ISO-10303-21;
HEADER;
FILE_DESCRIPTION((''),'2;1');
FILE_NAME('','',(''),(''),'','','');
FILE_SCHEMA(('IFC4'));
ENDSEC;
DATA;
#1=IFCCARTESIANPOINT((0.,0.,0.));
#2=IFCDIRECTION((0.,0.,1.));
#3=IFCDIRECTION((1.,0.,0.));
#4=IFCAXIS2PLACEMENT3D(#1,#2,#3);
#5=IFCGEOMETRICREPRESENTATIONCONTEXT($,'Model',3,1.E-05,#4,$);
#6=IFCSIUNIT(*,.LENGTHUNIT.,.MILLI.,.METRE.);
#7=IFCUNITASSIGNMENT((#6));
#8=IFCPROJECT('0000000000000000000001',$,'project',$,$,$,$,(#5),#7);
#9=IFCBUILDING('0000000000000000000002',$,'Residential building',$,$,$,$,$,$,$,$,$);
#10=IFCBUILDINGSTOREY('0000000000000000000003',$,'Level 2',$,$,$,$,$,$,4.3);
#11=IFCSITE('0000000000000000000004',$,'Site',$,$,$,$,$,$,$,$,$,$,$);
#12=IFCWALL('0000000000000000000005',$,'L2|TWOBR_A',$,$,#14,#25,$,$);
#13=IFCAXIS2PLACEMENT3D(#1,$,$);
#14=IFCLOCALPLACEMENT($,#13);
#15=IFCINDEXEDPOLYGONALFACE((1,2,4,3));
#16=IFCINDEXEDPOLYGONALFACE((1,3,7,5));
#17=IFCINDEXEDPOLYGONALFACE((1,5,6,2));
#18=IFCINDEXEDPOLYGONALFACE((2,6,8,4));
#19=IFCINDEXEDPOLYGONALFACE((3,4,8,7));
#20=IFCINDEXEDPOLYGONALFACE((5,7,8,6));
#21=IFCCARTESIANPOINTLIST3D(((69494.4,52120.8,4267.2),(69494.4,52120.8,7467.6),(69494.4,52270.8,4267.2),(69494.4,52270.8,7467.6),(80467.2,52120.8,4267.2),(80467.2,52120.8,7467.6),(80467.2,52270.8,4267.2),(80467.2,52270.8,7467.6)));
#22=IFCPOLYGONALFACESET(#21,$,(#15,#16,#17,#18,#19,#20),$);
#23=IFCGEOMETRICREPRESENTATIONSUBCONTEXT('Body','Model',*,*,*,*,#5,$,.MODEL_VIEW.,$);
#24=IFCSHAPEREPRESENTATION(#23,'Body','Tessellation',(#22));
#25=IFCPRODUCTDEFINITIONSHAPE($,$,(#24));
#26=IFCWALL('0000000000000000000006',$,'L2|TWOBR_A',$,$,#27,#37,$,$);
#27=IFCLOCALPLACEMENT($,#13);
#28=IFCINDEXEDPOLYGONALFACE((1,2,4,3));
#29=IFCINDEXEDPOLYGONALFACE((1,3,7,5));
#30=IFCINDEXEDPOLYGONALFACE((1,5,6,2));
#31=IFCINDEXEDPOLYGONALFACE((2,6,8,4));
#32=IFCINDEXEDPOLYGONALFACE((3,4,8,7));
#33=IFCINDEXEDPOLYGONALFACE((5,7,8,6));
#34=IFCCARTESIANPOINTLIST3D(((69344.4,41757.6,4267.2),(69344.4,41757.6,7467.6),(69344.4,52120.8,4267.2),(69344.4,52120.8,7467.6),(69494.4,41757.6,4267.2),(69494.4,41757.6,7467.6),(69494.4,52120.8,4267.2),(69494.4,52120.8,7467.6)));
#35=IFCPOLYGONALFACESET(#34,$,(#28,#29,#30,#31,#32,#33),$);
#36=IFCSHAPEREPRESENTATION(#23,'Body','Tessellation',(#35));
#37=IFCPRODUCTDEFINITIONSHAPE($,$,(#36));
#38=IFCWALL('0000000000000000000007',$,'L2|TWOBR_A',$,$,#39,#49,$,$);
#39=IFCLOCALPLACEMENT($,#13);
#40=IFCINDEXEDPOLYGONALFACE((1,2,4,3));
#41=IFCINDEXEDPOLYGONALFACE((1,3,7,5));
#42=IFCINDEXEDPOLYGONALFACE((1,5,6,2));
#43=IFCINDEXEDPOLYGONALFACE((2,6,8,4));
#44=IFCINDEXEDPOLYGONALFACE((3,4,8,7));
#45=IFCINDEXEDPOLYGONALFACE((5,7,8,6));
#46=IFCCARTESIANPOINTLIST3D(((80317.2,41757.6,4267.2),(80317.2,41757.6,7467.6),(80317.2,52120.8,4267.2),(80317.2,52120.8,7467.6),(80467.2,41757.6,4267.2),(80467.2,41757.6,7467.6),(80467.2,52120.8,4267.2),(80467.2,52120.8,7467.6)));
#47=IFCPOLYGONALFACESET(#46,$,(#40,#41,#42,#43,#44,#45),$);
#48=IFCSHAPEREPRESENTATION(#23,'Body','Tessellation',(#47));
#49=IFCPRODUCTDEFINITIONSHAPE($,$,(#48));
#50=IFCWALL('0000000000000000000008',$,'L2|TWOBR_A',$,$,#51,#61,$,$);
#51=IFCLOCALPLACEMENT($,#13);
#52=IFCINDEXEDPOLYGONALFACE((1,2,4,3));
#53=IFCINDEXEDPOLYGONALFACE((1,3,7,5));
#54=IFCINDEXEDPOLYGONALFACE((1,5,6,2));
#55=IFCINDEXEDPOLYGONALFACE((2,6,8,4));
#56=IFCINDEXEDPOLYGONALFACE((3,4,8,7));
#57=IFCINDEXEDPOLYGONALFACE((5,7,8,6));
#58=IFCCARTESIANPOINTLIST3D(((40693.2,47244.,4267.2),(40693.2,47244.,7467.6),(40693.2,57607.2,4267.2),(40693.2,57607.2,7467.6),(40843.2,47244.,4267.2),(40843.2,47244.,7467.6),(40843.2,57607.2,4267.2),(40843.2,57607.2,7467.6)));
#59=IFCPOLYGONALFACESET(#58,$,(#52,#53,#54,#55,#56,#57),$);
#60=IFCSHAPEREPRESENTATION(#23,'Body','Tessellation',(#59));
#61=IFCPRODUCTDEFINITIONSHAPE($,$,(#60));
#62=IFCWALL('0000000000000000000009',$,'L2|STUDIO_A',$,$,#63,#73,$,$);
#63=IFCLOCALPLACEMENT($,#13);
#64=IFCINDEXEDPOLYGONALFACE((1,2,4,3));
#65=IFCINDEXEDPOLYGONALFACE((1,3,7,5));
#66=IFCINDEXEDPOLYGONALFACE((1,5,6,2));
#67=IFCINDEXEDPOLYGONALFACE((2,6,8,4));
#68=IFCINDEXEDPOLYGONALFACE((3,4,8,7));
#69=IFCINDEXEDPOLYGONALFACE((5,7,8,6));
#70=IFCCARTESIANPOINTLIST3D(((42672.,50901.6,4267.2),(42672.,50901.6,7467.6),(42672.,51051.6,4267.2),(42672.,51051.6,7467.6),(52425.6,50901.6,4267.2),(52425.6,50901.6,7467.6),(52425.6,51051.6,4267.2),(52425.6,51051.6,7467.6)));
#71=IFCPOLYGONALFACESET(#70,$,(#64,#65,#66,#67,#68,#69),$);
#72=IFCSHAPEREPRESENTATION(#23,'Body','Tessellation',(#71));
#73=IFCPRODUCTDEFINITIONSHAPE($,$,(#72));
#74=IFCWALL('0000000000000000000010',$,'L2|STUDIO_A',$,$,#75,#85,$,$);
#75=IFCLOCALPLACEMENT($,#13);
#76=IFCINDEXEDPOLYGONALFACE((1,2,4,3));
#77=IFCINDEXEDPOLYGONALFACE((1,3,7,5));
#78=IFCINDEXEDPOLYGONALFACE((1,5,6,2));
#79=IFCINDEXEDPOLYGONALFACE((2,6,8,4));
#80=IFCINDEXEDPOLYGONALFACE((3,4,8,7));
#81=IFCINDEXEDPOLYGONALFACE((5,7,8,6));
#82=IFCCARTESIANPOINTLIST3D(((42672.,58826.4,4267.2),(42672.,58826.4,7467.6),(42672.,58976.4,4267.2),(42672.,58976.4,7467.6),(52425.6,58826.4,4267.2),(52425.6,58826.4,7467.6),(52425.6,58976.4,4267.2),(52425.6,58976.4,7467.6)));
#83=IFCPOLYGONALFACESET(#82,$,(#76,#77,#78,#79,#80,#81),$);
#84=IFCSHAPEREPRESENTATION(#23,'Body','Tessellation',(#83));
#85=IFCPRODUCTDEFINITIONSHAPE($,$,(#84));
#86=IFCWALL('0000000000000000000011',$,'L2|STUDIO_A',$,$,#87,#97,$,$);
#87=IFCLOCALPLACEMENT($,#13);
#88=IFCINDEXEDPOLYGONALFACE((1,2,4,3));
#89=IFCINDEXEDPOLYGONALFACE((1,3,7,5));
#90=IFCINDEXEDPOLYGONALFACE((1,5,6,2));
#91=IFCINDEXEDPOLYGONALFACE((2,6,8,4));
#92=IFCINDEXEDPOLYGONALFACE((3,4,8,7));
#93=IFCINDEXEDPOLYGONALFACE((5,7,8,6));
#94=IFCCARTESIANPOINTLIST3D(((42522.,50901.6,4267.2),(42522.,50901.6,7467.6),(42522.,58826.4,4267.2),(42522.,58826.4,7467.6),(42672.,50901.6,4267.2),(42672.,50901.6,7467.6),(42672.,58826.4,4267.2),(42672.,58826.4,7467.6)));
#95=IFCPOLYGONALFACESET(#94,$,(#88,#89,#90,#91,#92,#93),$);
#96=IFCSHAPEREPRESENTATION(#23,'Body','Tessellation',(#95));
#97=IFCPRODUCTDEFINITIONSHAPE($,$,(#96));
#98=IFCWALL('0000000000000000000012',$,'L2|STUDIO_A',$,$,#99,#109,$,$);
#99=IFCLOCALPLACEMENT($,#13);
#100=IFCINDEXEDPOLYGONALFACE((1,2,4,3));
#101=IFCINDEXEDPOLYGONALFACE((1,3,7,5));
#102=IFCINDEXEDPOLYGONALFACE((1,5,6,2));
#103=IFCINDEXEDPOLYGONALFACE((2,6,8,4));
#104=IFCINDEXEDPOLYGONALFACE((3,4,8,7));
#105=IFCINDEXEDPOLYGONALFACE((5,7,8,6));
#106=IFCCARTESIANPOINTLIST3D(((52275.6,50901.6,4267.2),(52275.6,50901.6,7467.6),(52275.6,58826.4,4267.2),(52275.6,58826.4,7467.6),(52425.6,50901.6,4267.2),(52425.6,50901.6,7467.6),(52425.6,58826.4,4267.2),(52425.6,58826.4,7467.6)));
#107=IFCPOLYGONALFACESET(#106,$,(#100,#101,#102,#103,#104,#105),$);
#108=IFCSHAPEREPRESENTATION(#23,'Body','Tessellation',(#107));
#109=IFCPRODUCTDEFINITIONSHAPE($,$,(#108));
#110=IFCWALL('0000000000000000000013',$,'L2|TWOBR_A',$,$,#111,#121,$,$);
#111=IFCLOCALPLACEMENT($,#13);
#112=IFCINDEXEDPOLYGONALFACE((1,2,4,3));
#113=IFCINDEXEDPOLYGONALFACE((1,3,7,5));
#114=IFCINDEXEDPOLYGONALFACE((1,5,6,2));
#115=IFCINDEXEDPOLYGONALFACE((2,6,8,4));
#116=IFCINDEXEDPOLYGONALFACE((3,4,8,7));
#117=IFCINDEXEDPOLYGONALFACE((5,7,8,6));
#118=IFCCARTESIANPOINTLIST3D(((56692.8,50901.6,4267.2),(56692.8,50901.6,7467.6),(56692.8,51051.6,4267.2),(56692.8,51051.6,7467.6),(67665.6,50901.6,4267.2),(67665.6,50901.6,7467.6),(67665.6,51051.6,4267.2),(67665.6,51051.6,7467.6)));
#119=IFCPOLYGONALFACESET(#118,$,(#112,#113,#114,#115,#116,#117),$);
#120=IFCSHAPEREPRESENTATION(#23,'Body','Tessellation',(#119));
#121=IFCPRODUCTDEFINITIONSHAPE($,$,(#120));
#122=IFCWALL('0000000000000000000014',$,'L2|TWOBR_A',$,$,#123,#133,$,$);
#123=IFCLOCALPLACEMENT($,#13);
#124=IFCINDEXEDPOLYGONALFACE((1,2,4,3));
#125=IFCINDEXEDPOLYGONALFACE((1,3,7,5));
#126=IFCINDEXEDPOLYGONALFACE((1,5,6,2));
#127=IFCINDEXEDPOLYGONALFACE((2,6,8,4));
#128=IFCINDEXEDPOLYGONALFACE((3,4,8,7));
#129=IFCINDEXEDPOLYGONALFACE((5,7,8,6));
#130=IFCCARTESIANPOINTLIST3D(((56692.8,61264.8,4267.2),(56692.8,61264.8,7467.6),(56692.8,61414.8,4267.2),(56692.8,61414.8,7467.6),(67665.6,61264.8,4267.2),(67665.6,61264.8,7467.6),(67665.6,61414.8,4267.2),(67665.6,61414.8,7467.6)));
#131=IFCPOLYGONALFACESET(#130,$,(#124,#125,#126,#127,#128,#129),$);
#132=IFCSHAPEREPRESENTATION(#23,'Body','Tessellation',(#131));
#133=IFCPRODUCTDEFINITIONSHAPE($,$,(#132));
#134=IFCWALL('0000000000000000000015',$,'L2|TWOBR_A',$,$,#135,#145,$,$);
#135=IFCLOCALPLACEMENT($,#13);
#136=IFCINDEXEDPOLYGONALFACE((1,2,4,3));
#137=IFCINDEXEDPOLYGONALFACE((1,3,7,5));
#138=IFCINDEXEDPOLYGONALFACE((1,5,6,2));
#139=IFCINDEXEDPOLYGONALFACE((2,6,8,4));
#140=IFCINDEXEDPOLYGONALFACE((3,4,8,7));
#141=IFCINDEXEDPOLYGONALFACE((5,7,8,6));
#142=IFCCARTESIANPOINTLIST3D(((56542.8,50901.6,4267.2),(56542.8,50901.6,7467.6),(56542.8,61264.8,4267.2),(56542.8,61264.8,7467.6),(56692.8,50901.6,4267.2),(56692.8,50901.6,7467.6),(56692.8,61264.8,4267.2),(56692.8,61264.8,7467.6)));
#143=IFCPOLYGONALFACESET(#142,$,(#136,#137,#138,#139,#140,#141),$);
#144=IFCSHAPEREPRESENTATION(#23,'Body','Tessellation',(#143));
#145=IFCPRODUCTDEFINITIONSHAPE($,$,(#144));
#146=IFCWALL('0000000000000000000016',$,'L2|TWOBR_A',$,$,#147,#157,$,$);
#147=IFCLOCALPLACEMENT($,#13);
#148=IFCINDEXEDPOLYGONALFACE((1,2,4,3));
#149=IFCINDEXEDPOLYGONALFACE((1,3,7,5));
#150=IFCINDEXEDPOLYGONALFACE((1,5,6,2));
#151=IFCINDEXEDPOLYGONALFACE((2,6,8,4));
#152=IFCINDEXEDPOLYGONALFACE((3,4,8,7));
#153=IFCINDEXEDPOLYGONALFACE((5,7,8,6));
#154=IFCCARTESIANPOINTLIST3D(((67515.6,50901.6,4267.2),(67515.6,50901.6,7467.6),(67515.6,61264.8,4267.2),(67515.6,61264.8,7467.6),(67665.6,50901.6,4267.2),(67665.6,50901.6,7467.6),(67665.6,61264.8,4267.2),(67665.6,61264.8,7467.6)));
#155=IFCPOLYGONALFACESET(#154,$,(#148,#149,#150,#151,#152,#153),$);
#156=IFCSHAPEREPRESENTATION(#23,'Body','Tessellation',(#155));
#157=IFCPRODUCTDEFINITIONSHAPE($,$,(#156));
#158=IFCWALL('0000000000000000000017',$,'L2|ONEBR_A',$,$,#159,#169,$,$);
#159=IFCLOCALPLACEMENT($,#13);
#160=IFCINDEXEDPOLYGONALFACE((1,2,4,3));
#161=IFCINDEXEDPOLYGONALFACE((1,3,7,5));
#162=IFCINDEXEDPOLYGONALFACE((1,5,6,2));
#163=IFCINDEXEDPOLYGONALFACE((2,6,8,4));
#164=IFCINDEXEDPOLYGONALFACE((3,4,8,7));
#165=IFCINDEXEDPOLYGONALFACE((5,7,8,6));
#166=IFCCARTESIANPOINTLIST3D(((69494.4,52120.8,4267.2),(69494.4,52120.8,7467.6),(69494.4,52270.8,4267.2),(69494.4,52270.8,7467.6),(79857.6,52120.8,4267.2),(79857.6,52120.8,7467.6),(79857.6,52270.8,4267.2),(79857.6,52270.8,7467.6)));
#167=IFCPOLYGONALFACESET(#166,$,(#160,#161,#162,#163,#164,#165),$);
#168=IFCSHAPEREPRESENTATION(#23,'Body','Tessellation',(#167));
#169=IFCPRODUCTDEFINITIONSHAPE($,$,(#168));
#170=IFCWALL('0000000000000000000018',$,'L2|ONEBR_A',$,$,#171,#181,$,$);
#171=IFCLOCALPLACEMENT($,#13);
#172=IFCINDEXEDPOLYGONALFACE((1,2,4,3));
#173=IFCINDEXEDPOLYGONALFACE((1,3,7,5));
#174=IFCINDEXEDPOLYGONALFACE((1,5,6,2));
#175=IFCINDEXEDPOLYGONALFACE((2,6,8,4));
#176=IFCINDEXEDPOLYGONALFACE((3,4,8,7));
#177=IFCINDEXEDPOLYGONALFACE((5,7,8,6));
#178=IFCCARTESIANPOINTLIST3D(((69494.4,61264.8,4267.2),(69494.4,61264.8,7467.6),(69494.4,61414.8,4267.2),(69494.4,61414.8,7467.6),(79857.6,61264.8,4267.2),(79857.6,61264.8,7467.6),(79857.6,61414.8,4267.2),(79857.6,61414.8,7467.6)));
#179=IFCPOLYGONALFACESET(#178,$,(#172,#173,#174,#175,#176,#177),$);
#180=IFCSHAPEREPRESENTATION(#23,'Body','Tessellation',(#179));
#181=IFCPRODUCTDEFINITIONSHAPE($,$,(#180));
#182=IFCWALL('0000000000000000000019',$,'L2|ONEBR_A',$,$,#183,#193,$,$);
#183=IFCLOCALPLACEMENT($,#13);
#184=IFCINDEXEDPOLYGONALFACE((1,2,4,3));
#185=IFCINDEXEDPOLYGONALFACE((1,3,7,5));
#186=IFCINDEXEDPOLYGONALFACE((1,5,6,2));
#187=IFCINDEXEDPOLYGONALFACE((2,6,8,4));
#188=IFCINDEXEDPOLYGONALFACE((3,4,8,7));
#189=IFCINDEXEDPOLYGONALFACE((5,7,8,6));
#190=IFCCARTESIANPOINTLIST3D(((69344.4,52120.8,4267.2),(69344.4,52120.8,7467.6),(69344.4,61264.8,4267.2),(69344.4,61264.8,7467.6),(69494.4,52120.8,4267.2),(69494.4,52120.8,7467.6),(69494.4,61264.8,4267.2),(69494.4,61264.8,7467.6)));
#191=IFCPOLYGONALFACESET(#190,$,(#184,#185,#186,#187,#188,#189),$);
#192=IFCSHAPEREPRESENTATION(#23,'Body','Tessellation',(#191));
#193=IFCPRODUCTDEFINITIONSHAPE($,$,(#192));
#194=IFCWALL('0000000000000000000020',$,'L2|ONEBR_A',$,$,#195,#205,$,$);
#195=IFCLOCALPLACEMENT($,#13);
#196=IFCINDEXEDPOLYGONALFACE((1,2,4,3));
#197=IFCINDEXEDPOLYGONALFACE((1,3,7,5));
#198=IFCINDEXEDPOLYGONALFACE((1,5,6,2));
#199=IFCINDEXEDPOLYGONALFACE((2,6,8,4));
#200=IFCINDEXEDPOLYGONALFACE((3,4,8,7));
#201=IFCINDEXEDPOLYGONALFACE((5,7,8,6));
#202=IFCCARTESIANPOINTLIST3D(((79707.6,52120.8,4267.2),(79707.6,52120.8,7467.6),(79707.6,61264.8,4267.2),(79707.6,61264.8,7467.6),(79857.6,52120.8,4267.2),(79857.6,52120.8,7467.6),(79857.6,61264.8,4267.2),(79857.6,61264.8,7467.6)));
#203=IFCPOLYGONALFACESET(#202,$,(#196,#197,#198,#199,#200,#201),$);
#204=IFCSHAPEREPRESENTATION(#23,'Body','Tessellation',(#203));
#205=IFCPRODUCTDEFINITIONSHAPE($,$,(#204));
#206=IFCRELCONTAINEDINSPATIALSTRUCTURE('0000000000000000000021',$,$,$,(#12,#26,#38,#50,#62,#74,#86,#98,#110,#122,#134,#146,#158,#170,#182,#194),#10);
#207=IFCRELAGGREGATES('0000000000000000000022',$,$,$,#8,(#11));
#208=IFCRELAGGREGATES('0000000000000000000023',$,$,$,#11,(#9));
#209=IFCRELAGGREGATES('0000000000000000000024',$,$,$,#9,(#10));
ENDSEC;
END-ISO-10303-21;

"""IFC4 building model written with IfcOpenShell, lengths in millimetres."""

from ifc_helpers import new_model, si_unit, frame, origin_with_axes, place, context, subcontext, project, spatial, indexed_curve, outline, extrude, element, save


model = new_model("IFC4")

# Units and contexts
model_context = context("Model", 3, precision=1e-05, world=origin_with_axes())
body_context = subcontext(model_context, "Body", "Model", "MODEL_VIEW")
ifc_project = project(units=[si_unit("LENGTHUNIT", "METRE", prefix="MILLI")], contexts=[model_context])

# Site, building, storey
site = spatial("IfcSite", under=ifc_project, Name="Site")
building = spatial("IfcBuilding", under=site, Name="Residential building")
storey = spatial("IfcBuildingStorey", under=building, Name="Level 2", Elevation=4.3)

# Walls
for number, where, z_axis, x_axis, name in (
    (1, (69494.4, 52120.8, 4267.2), (0.0, 0.0, 1.0), (1.0, 0.0, 0.0), "L2|TWOBR_A"),
):
    element("IfcWall", number, at=place(None, frame(where, z_axis=z_axis, x_axis=x_axis)), inside=storey, Name=name, context=body_context, shape_type="SweptSolid", body=[
        extrude(outline(indexed_curve([(0.0, 0.0), (0.0, 150.0), (10972.8, 150.0), (10972.8, 0.0), (0.0, 0.0)], self_intersect=False)), origin_with_axes(), (0.0, 0.0, 1.0), 3200.4),
    ])
for number, where, z_axis, x_axis, name in (
    (2, (69494.4, 41757.6, 4267.2), (0.0, 0.0, 1.0), (0.0, 1.0, 0.0), "L2|TWOBR_A"),
    (3, (80467.2, 41757.6, 4267.2), (0.0, 0.0, 1.0), (0.0, 1.0, 0.0), "L2|TWOBR_A"),
    (4, (40843.2, 47244.0, 4267.2), (0.0, 0.0, 1.0), (0.0, 1.0, 0.0), "L2|TWOBR_A"),
):
    element("IfcWall", number, at=place(None, frame(where, z_axis=z_axis, x_axis=x_axis)), inside=storey, Name=name, context=body_context, shape_type="SweptSolid", body=[
        extrude(outline(indexed_curve([(0.0, 0.0), (0.0, 150.0), (10363.2, 150.0), (10363.2, 0.0), (0.0, 0.0)], self_intersect=False)), origin_with_axes(), (0.0, 0.0, 1.0), 3200.4),
    ])
for number, where, z_axis, x_axis, name in (
    (5, (42672.0, 50901.6, 4267.2), (0.0, 0.0, 1.0), (1.0, 0.0, 0.0), "L2|STUDIO_A"),
    (6, (42672.0, 58826.4, 4267.2), (0.0, 0.0, 1.0), (1.0, 0.0, 0.0), "L2|STUDIO_A"),
):
    element("IfcWall", number, at=place(None, frame(where, z_axis=z_axis, x_axis=x_axis)), inside=storey, Name=name, context=body_context, shape_type="SweptSolid", body=[
        extrude(outline(indexed_curve([(0.0, 0.0), (0.0, 150.0), (9753.6, 150.0), (9753.6, 0.0), (0.0, 0.0)], self_intersect=False)), origin_with_axes(), (0.0, 0.0, 1.0), 3200.4),
    ])
for number, where, z_axis, x_axis, name in (
    (7, (42672.0, 50901.6, 4267.2), (0.0, 0.0, 1.0), (0.0, 1.0, 0.0), "L2|STUDIO_A"),
    (8, (52425.6, 50901.6, 4267.2), (0.0, 0.0, 1.0), (0.0, 1.0, 0.0), "L2|STUDIO_A"),
):
    element("IfcWall", number, at=place(None, frame(where, z_axis=z_axis, x_axis=x_axis)), inside=storey, Name=name, context=body_context, shape_type="SweptSolid", body=[
        extrude(outline(indexed_curve([(0.0, 0.0), (0.0, 150.0), (7924.8, 150.0), (7924.8, 0.0), (0.0, 0.0)], self_intersect=False)), origin_with_axes(), (0.0, 0.0, 1.0), 3200.4),
    ])
for number, where, z_axis, x_axis, name in (
    (9, (56692.8, 50901.6, 4267.2), (0.0, 0.0, 1.0), (1.0, 0.0, 0.0), "L2|TWOBR_A"),
    (10, (56692.8, 61264.8, 4267.2), (0.0, 0.0, 1.0), (1.0, 0.0, 0.0), "L2|TWOBR_A"),
):
    element("IfcWall", number, at=place(None, frame(where, z_axis=z_axis, x_axis=x_axis)), inside=storey, Name=name, context=body_context, shape_type="SweptSolid", body=[
        extrude(outline(indexed_curve([(0.0, 0.0), (0.0, 150.0), (10972.8, 150.0), (10972.8, 0.0), (0.0, 0.0)], self_intersect=False)), origin_with_axes(), (0.0, 0.0, 1.0), 3200.4),
    ])
for number, where, z_axis, x_axis, name in (
    (11, (56692.8, 50901.6, 4267.2), (0.0, 0.0, 1.0), (0.0, 1.0, 0.0), "L2|TWOBR_A"),
    (12, (67665.6, 50901.6, 4267.2), (0.0, 0.0, 1.0), (0.0, 1.0, 0.0), "L2|TWOBR_A"),
    (13, (69494.4, 52120.8, 4267.2), (0.0, 0.0, 1.0), (1.0, 0.0, 0.0), "L2|ONEBR_A"),
    (14, (69494.4, 61264.8, 4267.2), (0.0, 0.0, 1.0), (1.0, 0.0, 0.0), "L2|ONEBR_A"),
):
    element("IfcWall", number, at=place(None, frame(where, z_axis=z_axis, x_axis=x_axis)), inside=storey, Name=name, context=body_context, shape_type="SweptSolid", body=[
        extrude(outline(indexed_curve([(0.0, 0.0), (0.0, 150.0), (10363.2, 150.0), (10363.2, 0.0), (0.0, 0.0)], self_intersect=False)), origin_with_axes(), (0.0, 0.0, 1.0), 3200.4),
    ])
for number, where, z_axis, x_axis, name in (
    (15, (69494.4, 52120.8, 4267.2), (0.0, 0.0, 1.0), (0.0, 1.0, 0.0), "L2|ONEBR_A"),
    (16, (79857.6, 52120.8, 4267.2), (0.0, 0.0, 1.0), (0.0, 1.0, 0.0), "L2|ONEBR_A"),
):
    element("IfcWall", number, at=place(None, frame(where, z_axis=z_axis, x_axis=x_axis)), inside=storey, Name=name, context=body_context, shape_type="SweptSolid", body=[
        extrude(outline(indexed_curve([(0.0, 0.0), (0.0, 150.0), (9144.0, 150.0), (9144.0, 0.0), (0.0, 0.0)], self_intersect=False)), origin_with_axes(), (0.0, 0.0, 1.0), 3200.4),
    ])

save(model, "model.ifc")
